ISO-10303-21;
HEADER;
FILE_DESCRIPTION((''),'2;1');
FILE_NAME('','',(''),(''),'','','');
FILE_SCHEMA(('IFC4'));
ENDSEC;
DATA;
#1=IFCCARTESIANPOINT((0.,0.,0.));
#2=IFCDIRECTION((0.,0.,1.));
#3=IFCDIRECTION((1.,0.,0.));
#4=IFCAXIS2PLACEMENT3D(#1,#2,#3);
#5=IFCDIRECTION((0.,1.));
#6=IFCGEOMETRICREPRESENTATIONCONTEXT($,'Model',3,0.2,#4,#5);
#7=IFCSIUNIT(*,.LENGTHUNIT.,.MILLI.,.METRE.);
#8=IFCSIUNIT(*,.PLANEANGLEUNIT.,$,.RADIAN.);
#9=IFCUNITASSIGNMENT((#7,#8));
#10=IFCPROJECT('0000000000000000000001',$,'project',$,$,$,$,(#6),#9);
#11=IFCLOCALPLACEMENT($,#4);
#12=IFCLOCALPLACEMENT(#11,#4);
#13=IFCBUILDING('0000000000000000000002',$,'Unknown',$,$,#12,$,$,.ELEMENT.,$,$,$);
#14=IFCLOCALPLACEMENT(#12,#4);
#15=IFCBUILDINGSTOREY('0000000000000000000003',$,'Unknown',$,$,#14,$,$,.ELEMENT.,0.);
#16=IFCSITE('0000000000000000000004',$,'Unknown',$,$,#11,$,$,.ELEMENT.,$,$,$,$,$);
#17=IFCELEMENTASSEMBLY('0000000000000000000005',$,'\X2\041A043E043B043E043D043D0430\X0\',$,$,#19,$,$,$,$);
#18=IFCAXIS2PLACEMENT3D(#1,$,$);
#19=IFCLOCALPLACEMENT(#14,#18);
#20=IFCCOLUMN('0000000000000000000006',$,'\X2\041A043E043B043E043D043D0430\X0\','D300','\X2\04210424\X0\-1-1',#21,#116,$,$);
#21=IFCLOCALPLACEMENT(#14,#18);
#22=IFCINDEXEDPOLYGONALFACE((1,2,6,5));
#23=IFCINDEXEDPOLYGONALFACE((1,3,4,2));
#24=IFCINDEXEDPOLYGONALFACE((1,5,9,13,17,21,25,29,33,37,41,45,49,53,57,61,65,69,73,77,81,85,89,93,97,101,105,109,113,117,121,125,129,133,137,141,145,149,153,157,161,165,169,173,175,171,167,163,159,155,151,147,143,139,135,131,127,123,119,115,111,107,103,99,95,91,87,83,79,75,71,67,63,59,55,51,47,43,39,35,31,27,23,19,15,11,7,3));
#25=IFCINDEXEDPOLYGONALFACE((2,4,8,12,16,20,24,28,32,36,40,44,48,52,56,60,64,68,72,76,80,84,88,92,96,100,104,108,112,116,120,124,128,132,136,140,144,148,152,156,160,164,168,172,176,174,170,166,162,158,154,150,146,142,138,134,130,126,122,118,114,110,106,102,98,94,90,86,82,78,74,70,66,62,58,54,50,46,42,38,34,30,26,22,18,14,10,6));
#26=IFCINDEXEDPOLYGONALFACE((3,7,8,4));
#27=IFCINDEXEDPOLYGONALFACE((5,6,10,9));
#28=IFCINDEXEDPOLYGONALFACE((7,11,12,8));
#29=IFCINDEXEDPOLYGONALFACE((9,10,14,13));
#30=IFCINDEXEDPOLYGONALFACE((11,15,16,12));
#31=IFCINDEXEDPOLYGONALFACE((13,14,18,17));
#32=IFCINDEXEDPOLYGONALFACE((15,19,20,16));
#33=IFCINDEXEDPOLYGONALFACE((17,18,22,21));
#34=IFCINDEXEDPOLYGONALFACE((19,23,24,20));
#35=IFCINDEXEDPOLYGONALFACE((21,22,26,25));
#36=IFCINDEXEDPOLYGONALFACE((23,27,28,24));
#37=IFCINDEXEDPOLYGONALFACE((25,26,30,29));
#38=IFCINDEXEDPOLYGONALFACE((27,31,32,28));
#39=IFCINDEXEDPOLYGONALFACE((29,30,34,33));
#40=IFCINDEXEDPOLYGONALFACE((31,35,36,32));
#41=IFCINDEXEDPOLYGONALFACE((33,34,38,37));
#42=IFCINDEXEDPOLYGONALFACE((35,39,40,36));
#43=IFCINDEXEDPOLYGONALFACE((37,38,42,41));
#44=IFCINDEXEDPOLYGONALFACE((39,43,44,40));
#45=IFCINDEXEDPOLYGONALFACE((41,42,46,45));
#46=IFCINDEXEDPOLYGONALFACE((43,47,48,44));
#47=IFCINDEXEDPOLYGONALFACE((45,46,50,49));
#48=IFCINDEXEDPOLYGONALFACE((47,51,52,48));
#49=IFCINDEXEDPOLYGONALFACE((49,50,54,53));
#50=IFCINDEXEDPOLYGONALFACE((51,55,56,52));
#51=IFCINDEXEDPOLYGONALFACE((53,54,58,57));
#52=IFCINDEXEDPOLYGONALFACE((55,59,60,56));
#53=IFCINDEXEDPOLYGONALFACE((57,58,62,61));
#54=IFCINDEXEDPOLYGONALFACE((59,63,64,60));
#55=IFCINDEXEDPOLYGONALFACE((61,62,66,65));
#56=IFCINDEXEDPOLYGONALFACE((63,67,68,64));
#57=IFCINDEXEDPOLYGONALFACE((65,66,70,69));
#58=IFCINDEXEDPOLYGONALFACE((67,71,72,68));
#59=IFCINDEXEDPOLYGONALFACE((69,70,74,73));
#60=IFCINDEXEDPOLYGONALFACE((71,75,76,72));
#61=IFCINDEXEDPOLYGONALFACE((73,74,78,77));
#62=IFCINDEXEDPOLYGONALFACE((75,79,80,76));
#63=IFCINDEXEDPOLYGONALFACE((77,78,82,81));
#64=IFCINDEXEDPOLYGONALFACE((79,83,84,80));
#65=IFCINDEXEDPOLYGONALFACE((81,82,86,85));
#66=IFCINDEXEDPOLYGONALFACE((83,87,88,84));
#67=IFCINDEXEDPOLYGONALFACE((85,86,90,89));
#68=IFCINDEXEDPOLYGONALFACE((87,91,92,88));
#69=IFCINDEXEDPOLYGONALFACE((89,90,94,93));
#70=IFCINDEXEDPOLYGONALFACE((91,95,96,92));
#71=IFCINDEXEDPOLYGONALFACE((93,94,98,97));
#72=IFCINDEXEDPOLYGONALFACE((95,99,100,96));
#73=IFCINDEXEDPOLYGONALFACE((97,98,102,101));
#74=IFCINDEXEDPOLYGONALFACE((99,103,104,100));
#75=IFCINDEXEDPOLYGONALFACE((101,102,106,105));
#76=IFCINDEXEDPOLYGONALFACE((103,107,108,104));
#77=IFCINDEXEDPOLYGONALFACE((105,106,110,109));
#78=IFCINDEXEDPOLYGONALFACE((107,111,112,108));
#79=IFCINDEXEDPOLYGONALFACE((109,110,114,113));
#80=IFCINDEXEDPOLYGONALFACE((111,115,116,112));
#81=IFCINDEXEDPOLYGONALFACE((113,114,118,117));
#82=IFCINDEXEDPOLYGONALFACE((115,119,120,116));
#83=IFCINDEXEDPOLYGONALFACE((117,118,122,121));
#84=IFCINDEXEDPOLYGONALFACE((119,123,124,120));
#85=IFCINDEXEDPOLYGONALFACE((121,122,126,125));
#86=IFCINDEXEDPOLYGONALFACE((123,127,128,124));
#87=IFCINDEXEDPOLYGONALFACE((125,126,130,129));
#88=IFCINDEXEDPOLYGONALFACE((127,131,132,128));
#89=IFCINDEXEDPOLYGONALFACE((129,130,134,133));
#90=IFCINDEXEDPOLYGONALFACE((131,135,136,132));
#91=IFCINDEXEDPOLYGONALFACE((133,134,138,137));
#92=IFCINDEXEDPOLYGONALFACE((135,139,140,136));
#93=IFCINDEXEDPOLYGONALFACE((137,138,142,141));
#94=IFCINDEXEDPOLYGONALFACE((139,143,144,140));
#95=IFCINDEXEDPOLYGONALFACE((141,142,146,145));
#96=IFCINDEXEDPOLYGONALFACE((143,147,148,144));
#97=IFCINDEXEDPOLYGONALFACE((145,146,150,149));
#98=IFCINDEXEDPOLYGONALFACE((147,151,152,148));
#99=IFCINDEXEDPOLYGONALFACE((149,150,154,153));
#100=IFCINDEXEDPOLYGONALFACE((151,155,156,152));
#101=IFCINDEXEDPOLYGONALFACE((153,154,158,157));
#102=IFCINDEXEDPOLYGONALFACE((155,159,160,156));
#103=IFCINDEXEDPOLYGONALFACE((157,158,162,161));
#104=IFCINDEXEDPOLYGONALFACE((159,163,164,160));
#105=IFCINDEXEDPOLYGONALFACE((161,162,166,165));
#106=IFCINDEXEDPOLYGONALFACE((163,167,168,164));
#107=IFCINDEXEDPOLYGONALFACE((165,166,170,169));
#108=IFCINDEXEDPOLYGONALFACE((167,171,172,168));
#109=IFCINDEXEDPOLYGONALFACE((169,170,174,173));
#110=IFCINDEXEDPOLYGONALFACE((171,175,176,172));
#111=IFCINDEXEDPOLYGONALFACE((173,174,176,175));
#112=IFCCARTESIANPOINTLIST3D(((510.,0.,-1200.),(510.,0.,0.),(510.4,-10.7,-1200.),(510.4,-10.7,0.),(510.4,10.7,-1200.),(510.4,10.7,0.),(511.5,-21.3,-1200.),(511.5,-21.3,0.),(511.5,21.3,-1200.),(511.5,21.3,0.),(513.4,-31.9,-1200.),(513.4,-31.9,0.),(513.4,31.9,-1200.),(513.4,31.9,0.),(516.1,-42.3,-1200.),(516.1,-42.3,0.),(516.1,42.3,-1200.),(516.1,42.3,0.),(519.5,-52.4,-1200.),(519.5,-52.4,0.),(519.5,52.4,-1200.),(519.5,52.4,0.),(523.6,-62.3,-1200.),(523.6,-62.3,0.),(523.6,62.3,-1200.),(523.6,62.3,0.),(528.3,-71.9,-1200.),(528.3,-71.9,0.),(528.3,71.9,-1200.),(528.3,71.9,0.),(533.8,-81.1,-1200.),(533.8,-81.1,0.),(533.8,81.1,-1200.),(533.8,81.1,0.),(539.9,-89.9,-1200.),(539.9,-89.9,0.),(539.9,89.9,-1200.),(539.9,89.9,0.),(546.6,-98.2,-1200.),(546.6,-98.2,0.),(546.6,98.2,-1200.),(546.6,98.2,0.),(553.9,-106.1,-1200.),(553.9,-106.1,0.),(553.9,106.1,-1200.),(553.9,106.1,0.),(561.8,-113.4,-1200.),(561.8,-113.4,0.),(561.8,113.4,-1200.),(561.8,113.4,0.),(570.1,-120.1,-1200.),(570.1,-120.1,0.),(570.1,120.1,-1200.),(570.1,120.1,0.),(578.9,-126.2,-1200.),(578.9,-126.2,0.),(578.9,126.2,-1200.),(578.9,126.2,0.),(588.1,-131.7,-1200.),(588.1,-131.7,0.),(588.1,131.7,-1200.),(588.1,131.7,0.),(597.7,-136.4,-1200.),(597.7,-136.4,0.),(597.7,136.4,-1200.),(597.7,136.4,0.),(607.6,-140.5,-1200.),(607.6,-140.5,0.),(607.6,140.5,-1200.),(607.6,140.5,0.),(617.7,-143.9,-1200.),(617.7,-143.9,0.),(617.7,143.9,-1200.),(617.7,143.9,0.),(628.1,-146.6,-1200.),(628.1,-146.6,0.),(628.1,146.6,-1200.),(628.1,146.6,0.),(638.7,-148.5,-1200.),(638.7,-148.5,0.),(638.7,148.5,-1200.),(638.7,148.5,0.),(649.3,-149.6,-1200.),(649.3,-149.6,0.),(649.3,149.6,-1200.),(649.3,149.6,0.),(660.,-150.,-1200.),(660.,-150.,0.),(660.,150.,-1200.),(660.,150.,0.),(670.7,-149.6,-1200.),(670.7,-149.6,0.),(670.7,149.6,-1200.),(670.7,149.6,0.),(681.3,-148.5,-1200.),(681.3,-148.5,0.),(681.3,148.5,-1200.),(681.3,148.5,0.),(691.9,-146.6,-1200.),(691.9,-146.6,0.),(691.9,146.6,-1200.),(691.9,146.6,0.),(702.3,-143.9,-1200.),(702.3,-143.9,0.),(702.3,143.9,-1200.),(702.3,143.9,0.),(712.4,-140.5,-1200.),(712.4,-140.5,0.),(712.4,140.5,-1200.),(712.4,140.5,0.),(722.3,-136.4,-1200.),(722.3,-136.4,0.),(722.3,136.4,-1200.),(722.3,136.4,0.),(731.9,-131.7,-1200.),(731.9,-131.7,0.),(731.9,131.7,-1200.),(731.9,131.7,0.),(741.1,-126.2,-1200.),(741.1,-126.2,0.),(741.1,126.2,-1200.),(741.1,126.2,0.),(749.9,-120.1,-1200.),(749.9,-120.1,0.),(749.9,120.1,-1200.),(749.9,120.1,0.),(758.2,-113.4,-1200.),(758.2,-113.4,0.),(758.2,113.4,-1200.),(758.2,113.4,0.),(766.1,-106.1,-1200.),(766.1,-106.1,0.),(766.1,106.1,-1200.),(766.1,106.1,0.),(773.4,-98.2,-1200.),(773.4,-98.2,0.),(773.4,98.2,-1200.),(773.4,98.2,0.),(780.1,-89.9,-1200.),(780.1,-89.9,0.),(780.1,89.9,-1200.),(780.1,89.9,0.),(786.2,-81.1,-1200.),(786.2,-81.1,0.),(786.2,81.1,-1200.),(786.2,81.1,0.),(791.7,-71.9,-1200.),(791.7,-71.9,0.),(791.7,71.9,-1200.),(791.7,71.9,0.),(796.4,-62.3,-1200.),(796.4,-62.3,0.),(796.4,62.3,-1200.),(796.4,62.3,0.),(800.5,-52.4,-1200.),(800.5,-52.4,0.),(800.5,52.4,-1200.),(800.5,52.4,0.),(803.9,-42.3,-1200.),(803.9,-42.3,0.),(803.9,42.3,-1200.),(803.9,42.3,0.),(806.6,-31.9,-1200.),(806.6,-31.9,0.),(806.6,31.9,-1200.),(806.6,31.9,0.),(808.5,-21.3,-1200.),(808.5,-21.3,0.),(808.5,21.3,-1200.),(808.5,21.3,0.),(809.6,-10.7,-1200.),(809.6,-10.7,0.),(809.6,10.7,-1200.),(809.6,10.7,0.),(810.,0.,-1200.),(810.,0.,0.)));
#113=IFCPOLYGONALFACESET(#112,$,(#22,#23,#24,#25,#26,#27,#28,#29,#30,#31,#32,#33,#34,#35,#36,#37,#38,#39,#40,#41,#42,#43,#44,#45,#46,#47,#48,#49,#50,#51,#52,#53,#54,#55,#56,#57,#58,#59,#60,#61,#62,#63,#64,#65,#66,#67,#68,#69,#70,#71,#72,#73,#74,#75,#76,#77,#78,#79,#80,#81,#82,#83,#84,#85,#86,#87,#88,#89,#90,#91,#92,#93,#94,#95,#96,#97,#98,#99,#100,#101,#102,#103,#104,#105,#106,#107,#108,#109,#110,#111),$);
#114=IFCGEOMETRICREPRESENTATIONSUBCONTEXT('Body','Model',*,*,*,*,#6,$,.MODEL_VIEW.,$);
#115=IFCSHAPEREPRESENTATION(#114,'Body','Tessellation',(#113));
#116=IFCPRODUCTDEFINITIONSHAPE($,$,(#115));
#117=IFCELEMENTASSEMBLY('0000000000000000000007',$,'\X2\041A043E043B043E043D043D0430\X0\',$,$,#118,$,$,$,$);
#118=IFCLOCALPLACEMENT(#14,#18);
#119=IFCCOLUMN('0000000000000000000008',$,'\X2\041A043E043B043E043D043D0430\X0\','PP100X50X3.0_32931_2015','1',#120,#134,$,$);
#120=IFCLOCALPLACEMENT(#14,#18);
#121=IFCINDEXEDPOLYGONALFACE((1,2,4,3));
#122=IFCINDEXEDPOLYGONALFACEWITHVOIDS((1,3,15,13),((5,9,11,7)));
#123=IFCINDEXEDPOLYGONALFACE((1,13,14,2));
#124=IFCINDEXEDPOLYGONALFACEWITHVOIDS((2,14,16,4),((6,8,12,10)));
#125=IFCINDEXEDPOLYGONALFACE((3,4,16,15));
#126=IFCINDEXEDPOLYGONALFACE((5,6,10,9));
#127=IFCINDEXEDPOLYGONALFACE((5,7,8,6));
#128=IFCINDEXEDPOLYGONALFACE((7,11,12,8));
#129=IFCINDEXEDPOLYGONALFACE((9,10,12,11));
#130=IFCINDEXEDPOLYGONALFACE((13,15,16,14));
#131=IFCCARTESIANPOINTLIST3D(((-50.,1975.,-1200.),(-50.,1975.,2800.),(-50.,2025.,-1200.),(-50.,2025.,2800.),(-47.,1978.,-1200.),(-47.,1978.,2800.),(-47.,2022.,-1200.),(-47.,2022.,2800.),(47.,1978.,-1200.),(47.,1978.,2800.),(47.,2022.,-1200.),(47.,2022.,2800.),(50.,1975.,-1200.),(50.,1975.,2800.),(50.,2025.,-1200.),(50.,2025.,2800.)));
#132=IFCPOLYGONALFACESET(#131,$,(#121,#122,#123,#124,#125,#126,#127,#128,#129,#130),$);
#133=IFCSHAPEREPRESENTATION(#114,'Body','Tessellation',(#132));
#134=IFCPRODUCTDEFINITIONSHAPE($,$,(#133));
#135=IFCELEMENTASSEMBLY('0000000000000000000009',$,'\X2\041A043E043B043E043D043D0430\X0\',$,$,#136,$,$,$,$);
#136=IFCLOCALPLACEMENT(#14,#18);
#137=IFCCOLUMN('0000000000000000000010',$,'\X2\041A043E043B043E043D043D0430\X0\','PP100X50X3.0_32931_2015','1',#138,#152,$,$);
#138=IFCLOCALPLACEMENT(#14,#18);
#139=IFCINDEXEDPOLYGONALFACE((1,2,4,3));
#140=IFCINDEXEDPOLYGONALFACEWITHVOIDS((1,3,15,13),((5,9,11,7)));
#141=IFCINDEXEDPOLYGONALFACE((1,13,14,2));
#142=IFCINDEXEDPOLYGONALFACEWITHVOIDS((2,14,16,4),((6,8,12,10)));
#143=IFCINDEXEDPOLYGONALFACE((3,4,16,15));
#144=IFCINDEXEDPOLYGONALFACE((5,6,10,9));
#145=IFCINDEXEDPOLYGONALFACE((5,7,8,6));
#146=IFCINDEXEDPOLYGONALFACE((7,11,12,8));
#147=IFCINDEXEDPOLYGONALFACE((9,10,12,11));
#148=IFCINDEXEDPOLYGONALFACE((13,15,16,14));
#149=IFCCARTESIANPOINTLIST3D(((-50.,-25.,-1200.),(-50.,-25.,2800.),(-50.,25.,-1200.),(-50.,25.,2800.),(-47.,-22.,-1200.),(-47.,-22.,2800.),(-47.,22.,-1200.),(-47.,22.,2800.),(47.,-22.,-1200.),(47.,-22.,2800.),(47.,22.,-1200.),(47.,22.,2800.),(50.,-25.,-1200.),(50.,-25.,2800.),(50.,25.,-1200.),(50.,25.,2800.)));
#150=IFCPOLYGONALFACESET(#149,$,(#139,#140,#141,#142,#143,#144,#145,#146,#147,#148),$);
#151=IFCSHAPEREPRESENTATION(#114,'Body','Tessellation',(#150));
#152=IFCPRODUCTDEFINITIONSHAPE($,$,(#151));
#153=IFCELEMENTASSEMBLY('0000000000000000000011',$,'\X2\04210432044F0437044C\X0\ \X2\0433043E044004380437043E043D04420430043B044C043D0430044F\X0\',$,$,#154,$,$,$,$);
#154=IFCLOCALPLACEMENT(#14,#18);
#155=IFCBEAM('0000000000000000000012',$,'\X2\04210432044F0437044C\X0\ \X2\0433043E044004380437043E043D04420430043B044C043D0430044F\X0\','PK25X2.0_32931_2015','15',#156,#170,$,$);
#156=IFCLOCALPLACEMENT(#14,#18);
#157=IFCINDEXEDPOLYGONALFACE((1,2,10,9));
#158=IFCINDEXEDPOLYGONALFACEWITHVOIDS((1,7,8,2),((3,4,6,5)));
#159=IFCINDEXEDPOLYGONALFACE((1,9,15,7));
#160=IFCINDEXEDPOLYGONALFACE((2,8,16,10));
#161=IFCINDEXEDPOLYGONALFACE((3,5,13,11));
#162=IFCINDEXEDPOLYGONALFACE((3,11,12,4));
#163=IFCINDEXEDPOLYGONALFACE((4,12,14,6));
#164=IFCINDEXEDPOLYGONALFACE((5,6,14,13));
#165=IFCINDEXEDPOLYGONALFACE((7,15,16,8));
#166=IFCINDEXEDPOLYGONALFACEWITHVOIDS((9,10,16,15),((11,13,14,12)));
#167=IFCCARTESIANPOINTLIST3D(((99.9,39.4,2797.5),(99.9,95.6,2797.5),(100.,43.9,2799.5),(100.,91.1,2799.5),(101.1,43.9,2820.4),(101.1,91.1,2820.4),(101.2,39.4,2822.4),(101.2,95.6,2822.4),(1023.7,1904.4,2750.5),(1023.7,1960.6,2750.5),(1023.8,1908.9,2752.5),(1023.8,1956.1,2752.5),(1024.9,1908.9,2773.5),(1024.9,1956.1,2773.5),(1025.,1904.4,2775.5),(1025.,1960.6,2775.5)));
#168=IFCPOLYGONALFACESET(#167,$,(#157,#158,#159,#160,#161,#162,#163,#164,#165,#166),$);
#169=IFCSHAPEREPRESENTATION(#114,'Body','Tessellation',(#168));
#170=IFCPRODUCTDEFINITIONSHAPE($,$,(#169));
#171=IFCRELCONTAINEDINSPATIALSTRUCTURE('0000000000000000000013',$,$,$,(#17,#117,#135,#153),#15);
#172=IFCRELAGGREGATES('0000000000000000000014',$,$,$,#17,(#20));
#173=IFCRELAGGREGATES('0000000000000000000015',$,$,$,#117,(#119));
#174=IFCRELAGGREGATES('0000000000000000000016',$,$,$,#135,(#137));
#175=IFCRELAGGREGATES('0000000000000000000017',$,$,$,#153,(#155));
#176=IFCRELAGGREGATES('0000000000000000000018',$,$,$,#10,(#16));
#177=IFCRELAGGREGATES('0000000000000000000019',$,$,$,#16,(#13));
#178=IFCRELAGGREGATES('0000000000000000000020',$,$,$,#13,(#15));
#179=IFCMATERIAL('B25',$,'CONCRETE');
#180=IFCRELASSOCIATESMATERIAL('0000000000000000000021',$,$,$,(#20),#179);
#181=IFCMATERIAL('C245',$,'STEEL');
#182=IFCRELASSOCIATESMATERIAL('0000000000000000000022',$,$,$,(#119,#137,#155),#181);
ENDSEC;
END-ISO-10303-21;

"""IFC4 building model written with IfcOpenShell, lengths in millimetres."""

from ifc_helpers import new_model, si_unit, direction, frame, origin_with_axes, place, context, subcontext, project, spatial, line, indexed_curve, outline, extrude, material, element, aggregate, save


model = new_model("IFC4")

# Units and contexts
model_context = context("Model", 3, precision=0.2, world=origin_with_axes(), true_north=direction((0.0, 1.0)))
body_context = subcontext(model_context, "Body", "Model", "MODEL_VIEW")
ifc_project = project(units=[si_unit("LENGTHUNIT", "METRE", prefix="MILLI"), si_unit("PLANEANGLEUNIT", "RADIAN")], contexts=[model_context])

# Site, building, storey
site_placement = place(None, origin_with_axes())
site = spatial("IfcSite", under=ifc_project, at=site_placement, Name="Unknown", CompositionType="ELEMENT")
building_placement = place(site_placement, origin_with_axes())
building = spatial("IfcBuilding", under=site, at=building_placement, Name="Unknown", CompositionType="ELEMENT")
storey_placement = place(building_placement, origin_with_axes())
storey = spatial("IfcBuildingStorey", under=building, at=storey_placement, Name="Unknown", CompositionType="ELEMENT", Elevation=0.0)

# Element assemblies, columns
ifc_material_1 = material(Name="B25", Category="CONCRETE")
assembly_1_placement = place(storey_placement, frame((660.0, 0.0, -1200.0), z_axis=(-1.0, 0.0, 0.0), x_axis=(0.0, 0.0, 1.0)))
assembly_1 = element("IfcElementAssembly", 1, at=assembly_1_placement, inside=storey, Name="Колонна")
column_1_placement = place(assembly_1_placement, origin_with_axes())
column_1 = element("IfcColumn", 2, at=column_1_placement, material=ifc_material_1, Name="Колонна", Description="D300", ObjectType="СФ-1-1", context=body_context, shape_type="SolidModel", body=[
    extrude(outline(indexed_curve([(150.0, 0.0), (149.6, 10.7), (148.5, 21.3), (146.6, 31.9), (143.9, 42.3), (140.5, 52.4), (136.4, 62.3), (131.7, 71.9), (126.2, 81.1), (120.1, 89.9), (113.4, 98.2), (106.1, 106.1), (98.2, 113.4), (89.9, 120.1), (81.1, 126.2), (71.9, 131.7), (62.3, 136.4), (52.4, 140.5), (42.3, 143.9), (31.9, 146.6), (21.3, 148.5), (10.7, 149.6), (0.0, 150.0), (-10.7, 149.6), (-21.3, 148.5), (-31.9, 146.6), (-42.3, 143.9), (-52.4, 140.5), (-62.3, 136.4), (-71.9, 131.7), (-81.1, 126.2), (-89.9, 120.1), (-98.2, 113.4), (-106.1, 106.1), (-113.4, 98.2), (-120.1, 89.9), (-126.2, 81.1), (-131.7, 71.9), (-136.4, 62.3), (-140.5, 52.4), (-143.9, 42.3), (-146.6, 31.9), (-148.5, 21.3), (-149.6, 10.7), (-150.0, 0.0), (-149.6, -10.7), (-148.5, -21.3), (-146.6, -31.9), (-143.9, -42.3), (-140.5, -52.4), (-136.4, -62.3), (-131.7, -71.9), (-126.2, -81.1), (-120.1, -89.9), (-113.4, -98.2), (-106.1, -106.1), (-98.2, -113.4), (-89.9, -120.1), (-81.1, -126.2), (-71.9, -131.7), (-62.3, -136.4), (-52.4, -140.5), (-42.3, -143.9), (-31.9, -146.6), (-21.3, -148.5), (-10.7, -149.6), (0.0, -150.0), (10.7, -149.6), (21.3, -148.5), (31.9, -146.6), (42.3, -143.9), (52.4, -140.5), (62.3, -136.4), (71.9, -131.7), (81.1, -126.2), (89.9, -120.1), (98.2, -113.4), (106.1, -106.1), (113.4, -98.2), (120.1, -89.9), (126.2, -81.1), (131.7, -71.9), (136.4, -62.3), (140.5, -52.4), (143.9, -42.3), (146.6, -31.9), (148.5, -21.3), (149.6, -10.7)], segments=[line(1, 2, 3, 4, 5, 6, 7, 8, 9, 10, 11, 12, 13, 14, 15, 16, 17, 18, 19, 20, 21, 22, 23, 24, 25, 26, 27, 28, 29, 30, 31, 32, 33, 34, 35, 36, 37, 38, 39, 40, 41, 42, 43, 44, 45, 46, 47, 48, 49, 50, 51, 52, 53, 54, 55, 56, 57, 58, 59, 60, 61, 62, 63, 64, 65, 66, 67, 68, 69, 70, 71, 72, 73, 74, 75, 76, 77, 78, 79, 80, 81, 82, 83, 84, 85, 86, 87, 88, 1)])), frame((0.0, 0.0, 0.0), z_axis=(-1.0, 0.0, 0.0), x_axis=(0.0, 0.0, 1.0)), (0.0, 0.0, -1.0), 1200.0),
])
aggregate(assembly_1, [column_1])
assembly_2_placement = place(storey_placement, frame((0.0, 2000.0, -1200.0), z_axis=(0.0, -1.0, 0.0), x_axis=(0.0, 0.0, 1.0)))
assembly_2 = element("IfcElementAssembly", 3, at=assembly_2_placement, inside=storey, Name="Колонна")
ifc_material_2 = material(Name="C245", Category="STEEL")
column_2_placement = place(assembly_2_placement, origin_with_axes())
column_2 = element("IfcColumn", 4, at=column_2_placement, material=ifc_material_2, Name="Колонна", Description="PP100X50X3.0_32931_2015", ObjectType="1", context=body_context, shape_type="SolidModel", body=[
    extrude(outline(indexed_curve([(-25.0, -50.0), (25.0, -50.0), (25.0, 50.0), (-25.0, 50.0)], segments=[line(1, 2, 3, 4, 1)]), holes=[indexed_curve([(-22.0, -47.0), (-22.0, 47.0), (22.0, 47.0), (22.0, -47.0)], segments=[line(1, 2, 3, 4, 1)])]), frame((0.0, 0.0, 0.0), z_axis=(-1.0, 0.0, 0.0), x_axis=(0.0, 0.0, 1.0)), (0.0, 0.0, -1.0), 4000.0),
])
aggregate(assembly_2, [column_2])
assembly_3_placement = place(storey_placement, frame((0.0, 0.0, -1200.0), z_axis=(0.0, -1.0, 0.0), x_axis=(0.0, 0.0, 1.0)))
assembly_3 = element("IfcElementAssembly", 5, at=assembly_3_placement, inside=storey, Name="Колонна")
column_3_placement = place(assembly_3_placement, origin_with_axes())
column_3 = element("IfcColumn", 6, at=column_3_placement, material=ifc_material_2, Name="Колонна", Description="PP100X50X3.0_32931_2015", ObjectType="1", context=body_context, shape_type="SolidModel", body=[
    extrude(outline(indexed_curve([(-25.0, -50.0), (25.0, -50.0), (25.0, 50.0), (-25.0, 50.0)], segments=[line(1, 2, 3, 4, 1)]), holes=[indexed_curve([(-22.0, -47.0), (-22.0, 47.0), (22.0, 47.0), (22.0, -47.0)], segments=[line(1, 2, 3, 4, 1)])]), frame((0.0, 0.0, 0.0), z_axis=(-1.0, 0.0, 0.0), x_axis=(0.0, 0.0, 1.0)), (0.0, 0.0, -1.0), 4000.0),
])
aggregate(assembly_3, [column_3])

# Element assembly, beam, voiding features
assembly_4_placement = place(storey_placement, frame((73.4, 12.6, 2811.3), z_axis=(0.894709, -0.444326, -0.045494), x_axis=(0.443753, 0.895865, -0.022564)))
assembly_4 = element("IfcElementAssembly", 7, at=assembly_4_placement, inside=storey, Name="Связь горизонтальная")
beam_1_placement = place(assembly_4_placement, origin_with_axes())
beam_1 = element("IfcBeam", 8, at=beam_1_placement, material=ifc_material_2, Name="Связь горизонтальная", Description="PK25X2.0_32931_2015", ObjectType="15", context=body_context, shape_type="SolidModel", body=[
    extrude(outline(indexed_curve([(-12.5, -12.5), (12.5, -12.5), (12.5, 12.5), (-12.5, 12.5)], segments=[line(1, 2, 3, 4, 1)]), holes=[indexed_curve([(-10.5, -10.5), (-10.5, 10.5), (10.5, 10.5), (10.5, -10.5)], segments=[line(1, 2, 3, 4, 1)])]), frame((0.0, 0.0, 0.0), z_axis=(-1.0, 0.0, 0.0), x_axis=(0.0, 0.0, 1.0)), (0.0, 0.0, -1.0), 2204.4),
])
voiding_feature_1_placement = place(beam_1_placement, frame((1204.9, 12.5, 493.2), z_axis=(0.444326, 0.0, 0.895865), x_axis=(0.895865, 0.0, -0.444326)))
element("IfcVoidingFeature", 9, at=voiding_feature_1_placement, cuts=beam_1, Name="CUT_BEAM", ObjectType="(?)", PredefinedType="HOLE", context=body_context, shape_type="SolidModel", body=[
    extrude(outline(indexed_curve([(-25.0, -25.0), (25.0, -25.0), (25.0, 25.0), (-25.0, 25.0)], segments=[line(1, 2, 3, 4, 1)])), frame((0.0, 0.0, 0.0), z_axis=(-1.0, 0.0, 0.0), x_axis=(0.0, 0.0, 1.0)), (0.0, 0.0, -1.0), 2220.1),
])
voiding_feature_2_placement = place(beam_1_placement, frame((-989.4, 12.5, 493.2), z_axis=(0.444326, 0.0, 0.895865), x_axis=(0.895865, 0.0, -0.444326)))
element("IfcVoidingFeature", 10, at=voiding_feature_2_placement, cuts=beam_1, Name="CUT_BEAM", ObjectType="(?)", PredefinedType="HOLE", context=body_context, shape_type="SolidModel", body=[
    extrude(outline(indexed_curve([(-25.0, -25.0), (25.0, -25.0), (25.0, 25.0), (-25.0, 25.0)], segments=[line(1, 2, 3, 4, 1)])), frame((0.0, 0.0, 0.0), z_axis=(-1.0, 0.0, 0.0), x_axis=(0.0, 0.0, 1.0)), (0.0, 0.0, -1.0), 2220.1),
])
aggregate(assembly_4, [beam_1])

save(model, "model.ifc")
